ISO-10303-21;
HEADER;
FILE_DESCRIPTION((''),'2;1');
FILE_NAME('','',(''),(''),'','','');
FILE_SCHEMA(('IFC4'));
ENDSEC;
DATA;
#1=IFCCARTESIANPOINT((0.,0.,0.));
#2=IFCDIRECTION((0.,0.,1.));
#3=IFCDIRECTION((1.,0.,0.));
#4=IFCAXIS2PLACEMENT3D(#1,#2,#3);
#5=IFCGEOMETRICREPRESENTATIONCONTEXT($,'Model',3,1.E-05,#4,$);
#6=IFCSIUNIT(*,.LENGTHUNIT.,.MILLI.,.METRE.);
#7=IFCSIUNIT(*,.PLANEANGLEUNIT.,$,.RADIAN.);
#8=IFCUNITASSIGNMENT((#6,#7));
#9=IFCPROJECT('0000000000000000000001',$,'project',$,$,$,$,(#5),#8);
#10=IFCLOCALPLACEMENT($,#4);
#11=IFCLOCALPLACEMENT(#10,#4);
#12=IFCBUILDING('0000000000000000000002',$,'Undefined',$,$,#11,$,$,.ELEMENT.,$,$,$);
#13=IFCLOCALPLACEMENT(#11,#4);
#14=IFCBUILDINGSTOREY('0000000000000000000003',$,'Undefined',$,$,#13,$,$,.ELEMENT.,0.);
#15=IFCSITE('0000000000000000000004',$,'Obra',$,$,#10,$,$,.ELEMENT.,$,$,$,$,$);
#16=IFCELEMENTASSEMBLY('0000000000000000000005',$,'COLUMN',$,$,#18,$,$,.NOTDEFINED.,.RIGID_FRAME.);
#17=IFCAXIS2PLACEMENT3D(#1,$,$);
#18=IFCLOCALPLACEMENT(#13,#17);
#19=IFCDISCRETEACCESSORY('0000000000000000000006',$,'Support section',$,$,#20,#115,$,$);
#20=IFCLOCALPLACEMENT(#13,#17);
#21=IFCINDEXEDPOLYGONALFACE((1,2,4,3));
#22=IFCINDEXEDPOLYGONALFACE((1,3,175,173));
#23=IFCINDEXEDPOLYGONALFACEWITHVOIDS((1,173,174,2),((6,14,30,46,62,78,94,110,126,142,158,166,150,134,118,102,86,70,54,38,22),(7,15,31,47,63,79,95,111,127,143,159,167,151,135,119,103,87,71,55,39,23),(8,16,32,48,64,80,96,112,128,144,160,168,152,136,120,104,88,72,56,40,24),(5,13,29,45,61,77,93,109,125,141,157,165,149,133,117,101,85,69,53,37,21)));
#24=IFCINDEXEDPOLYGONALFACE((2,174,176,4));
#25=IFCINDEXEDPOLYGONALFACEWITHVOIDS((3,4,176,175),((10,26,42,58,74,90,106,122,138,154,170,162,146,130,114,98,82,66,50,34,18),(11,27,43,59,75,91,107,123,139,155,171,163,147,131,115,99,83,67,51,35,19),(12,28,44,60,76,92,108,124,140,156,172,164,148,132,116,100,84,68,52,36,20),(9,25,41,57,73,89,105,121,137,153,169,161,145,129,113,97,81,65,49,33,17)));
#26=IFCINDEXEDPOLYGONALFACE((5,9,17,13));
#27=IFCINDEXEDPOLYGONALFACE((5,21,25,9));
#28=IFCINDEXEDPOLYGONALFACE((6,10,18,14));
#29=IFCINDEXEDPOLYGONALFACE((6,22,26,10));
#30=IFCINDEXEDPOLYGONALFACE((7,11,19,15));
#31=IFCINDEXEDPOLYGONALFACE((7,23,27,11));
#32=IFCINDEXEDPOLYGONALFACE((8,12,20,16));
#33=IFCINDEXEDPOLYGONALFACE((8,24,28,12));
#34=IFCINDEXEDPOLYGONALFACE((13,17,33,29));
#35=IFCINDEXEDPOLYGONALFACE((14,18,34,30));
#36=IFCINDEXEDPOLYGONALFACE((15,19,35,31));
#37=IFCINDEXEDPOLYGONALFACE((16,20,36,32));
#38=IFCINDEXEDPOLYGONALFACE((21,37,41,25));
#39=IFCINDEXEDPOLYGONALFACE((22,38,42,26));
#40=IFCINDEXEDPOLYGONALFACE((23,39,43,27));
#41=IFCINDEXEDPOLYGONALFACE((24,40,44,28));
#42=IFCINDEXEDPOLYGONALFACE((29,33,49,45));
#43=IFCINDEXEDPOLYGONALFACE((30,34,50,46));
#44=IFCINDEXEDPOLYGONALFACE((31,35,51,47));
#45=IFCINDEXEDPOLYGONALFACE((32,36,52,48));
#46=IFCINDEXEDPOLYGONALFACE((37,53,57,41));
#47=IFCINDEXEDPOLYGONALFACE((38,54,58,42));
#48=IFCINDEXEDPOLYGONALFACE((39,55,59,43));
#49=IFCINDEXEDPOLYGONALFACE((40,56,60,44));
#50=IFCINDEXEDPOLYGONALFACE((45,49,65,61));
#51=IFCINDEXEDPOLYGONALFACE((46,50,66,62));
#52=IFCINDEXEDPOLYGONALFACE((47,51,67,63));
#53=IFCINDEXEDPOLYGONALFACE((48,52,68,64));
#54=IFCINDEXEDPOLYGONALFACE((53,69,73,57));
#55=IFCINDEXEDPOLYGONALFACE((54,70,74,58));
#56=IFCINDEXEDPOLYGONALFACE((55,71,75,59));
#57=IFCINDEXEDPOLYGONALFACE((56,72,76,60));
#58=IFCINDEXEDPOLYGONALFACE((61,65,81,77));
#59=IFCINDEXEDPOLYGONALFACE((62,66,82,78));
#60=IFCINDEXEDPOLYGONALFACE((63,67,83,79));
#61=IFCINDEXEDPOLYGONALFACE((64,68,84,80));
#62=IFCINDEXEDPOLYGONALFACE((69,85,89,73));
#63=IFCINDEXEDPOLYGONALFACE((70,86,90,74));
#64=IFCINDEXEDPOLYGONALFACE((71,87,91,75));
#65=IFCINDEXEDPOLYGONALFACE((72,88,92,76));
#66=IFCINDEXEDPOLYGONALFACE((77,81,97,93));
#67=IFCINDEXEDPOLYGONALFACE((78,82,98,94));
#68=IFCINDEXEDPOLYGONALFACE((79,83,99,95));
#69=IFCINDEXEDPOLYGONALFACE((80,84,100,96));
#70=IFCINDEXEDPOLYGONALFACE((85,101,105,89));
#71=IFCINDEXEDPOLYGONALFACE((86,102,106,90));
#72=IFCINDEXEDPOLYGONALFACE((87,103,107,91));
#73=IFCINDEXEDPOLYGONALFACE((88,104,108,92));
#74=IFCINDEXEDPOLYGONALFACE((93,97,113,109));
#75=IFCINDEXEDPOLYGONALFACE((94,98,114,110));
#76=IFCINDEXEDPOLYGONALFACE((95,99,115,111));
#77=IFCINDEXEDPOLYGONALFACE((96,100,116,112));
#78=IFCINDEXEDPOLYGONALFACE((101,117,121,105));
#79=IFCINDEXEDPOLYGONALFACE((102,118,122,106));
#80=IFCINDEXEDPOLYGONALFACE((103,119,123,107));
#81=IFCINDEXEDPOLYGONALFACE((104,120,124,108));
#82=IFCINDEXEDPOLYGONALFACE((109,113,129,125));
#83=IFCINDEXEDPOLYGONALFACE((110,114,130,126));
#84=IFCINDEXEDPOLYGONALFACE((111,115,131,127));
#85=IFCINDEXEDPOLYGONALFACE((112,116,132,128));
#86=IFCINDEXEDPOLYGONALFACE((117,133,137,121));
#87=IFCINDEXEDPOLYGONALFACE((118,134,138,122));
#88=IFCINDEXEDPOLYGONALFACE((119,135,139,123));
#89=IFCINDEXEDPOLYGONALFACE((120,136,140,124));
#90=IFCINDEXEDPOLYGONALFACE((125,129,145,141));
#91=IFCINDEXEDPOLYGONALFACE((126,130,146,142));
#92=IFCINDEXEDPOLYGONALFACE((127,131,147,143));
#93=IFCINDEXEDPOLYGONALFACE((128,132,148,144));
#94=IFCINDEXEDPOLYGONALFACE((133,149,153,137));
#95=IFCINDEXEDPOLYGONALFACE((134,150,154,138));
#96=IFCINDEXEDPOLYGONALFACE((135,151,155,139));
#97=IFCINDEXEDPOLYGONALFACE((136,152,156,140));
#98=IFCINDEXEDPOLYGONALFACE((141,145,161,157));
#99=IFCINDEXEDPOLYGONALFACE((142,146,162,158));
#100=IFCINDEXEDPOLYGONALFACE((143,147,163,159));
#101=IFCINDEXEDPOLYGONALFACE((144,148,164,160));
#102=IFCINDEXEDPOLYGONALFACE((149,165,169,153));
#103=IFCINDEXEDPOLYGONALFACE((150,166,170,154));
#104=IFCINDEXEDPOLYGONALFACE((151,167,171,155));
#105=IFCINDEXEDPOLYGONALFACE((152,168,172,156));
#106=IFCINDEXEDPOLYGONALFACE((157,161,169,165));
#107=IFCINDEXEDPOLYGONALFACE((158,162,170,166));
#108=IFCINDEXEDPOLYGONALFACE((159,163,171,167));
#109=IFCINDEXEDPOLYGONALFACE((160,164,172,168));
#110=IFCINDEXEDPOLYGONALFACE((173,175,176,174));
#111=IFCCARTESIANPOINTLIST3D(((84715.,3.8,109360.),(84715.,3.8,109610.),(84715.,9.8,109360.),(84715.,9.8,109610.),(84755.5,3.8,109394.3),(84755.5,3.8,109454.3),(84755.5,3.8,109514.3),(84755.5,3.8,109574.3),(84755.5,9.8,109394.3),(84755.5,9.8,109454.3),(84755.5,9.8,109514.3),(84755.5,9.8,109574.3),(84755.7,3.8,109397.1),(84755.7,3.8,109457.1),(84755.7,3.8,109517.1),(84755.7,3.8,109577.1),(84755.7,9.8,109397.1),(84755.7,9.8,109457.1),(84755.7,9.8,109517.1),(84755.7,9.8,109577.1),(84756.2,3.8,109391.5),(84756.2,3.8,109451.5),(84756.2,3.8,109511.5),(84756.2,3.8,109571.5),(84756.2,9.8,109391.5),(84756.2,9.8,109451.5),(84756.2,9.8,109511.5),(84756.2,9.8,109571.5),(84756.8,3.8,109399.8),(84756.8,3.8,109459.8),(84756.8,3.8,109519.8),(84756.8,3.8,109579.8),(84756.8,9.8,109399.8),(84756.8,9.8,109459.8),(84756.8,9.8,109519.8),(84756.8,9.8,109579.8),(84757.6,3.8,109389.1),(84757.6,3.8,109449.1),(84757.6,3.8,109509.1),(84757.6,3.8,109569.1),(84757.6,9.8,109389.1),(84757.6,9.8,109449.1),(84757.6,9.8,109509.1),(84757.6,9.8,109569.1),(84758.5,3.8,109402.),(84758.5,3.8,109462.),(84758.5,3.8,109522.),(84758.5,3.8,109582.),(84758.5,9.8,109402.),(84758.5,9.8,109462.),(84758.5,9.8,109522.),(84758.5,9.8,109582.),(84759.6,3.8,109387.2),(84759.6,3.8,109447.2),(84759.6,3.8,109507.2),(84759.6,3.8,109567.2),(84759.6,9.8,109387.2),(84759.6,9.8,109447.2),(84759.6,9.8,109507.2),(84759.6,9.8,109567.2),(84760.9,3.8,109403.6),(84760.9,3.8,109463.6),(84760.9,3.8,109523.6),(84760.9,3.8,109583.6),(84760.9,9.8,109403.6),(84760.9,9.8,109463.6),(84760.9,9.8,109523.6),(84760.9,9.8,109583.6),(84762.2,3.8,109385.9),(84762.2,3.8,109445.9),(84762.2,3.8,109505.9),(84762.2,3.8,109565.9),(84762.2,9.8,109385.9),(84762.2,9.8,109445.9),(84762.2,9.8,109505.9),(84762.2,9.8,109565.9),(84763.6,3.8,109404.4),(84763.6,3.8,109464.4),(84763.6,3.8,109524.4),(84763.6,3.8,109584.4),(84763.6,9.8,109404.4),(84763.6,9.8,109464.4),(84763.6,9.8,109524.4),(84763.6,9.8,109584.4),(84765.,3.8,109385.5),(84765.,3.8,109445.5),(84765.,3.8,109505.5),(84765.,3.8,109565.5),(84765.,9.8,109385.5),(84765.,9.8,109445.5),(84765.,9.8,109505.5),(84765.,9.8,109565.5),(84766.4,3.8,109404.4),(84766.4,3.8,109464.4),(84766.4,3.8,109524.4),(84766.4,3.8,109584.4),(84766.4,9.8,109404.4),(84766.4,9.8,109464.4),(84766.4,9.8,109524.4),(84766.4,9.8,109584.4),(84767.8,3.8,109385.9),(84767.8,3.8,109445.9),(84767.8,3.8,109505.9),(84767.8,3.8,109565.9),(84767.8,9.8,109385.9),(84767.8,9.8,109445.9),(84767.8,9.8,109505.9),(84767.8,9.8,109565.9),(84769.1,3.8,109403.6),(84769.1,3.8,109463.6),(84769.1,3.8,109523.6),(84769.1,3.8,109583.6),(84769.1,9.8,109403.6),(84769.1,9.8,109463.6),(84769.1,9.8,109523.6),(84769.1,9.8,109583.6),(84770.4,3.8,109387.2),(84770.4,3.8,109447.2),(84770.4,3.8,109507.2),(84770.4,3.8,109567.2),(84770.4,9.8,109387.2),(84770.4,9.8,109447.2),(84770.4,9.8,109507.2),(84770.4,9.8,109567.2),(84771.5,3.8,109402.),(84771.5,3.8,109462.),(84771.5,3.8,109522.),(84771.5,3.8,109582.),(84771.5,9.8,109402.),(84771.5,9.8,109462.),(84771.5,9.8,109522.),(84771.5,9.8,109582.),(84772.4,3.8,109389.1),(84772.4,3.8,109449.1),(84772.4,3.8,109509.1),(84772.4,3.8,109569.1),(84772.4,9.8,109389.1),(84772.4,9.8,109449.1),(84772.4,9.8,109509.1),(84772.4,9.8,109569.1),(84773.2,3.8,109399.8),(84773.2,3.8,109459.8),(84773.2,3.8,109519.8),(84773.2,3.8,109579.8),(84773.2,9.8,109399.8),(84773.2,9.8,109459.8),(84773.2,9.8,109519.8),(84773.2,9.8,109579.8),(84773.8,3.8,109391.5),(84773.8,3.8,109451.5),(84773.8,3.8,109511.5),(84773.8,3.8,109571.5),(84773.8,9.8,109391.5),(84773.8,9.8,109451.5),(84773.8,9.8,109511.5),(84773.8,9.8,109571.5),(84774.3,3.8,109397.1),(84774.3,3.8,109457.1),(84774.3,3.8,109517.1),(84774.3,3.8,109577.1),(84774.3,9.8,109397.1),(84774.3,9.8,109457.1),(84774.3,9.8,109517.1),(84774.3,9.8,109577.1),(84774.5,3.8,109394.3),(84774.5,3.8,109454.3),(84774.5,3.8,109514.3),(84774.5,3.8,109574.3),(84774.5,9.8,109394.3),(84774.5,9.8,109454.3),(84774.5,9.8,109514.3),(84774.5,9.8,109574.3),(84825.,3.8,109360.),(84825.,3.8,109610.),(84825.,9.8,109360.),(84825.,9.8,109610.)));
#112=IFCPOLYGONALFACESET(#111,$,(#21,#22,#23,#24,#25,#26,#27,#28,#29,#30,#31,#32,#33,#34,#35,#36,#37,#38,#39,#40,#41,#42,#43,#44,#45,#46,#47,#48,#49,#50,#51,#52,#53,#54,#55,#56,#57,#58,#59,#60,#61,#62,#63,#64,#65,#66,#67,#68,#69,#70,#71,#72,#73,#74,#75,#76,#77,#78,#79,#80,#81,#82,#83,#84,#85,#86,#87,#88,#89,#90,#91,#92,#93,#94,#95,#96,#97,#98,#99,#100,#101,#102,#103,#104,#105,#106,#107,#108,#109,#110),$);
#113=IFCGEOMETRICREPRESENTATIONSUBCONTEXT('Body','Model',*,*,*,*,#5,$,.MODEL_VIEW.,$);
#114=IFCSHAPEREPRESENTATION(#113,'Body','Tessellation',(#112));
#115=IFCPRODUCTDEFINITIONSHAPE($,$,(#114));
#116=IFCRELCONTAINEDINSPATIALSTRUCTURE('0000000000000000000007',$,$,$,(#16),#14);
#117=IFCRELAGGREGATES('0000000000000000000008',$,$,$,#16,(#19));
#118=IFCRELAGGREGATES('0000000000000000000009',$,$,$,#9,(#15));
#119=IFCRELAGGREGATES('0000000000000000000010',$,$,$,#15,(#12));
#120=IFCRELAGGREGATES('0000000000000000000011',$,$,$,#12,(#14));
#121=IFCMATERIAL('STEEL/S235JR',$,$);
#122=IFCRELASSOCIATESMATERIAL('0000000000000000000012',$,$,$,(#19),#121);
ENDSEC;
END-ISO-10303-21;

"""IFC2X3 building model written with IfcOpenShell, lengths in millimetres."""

from ifc_helpers import new_model, si_unit, frame, origin_with_axes, origin_2d_with_axis, place, context, subcontext, project, spatial, rectangle, circle, extrude, source, transform, mapped, material, element, aggregate, save


model = new_model("IFC2X3")

# Units and contexts
model_context = context("Model", 3, precision=1e-05, world=origin_with_axes())
body_context = subcontext(model_context, "Body", "Model", "MODEL_VIEW")
ifc_project = project(units=[si_unit("LENGTHUNIT", "METRE", prefix="MILLI"), si_unit("PLANEANGLEUNIT", "RADIAN")], contexts=[model_context])

# Site, building, storey
site_placement = place(None, origin_with_axes())
site = spatial("IfcSite", under=ifc_project, at=site_placement, Name="Obra", CompositionType="ELEMENT")
building_placement = place(site_placement, origin_with_axes())
building = spatial("IfcBuilding", under=site, at=building_placement, Name="Undefined", CompositionType="ELEMENT")
storey_placement = place(building_placement, origin_with_axes())
storey = spatial("IfcBuildingStorey", under=building, at=storey_placement, Name="Undefined", CompositionType="ELEMENT", Elevation=0.0)

# Element assembly, discrete accessory, opening
assembly_1_placement = place(storey_placement, origin_with_axes())
assembly_1 = element("IfcElementAssembly", 1, at=assembly_1_placement, inside=storey, Name="COLUMN", AssemblyPlace="NOTDEFINED", PredefinedType="RIGID_FRAME")
ifc_material_1 = material(Name="STEEL/S235JR")
shared_shape_1 = source(origin_with_axes(), body_context, "Body", "SweptSolid", [
    extrude(circle(Radius=9.5, at=origin_2d_with_axis()), frame((0.0, -9.8, 0.0), z_axis=(0.0, 1.0, 0.0), x_axis=(1.0, 0.0, 0.0)), (0.0, 0.0, 1.0), 6.2),
])
discrete_accessory_1_placement = place(assembly_1_placement, frame((84770.0, 6.8, 109360.0), z_axis=(0.0, 0.0, 1.0), x_axis=(1.0, 0.0, 0.0)))
discrete_accessory_1 = element("IfcDiscreteAccessory", 2, at=discrete_accessory_1_placement, material=ifc_material_1, Name="Support section", context=body_context, shape_type="SweptSolid", body=[
    extrude(rectangle(XDim=6.0, YDim=110.0, at=origin_2d_with_axis()), frame((0.0, 0.0, 250.0), z_axis=(0.0, 0.0, -1.0), x_axis=(0.0, 1.0, 0.0)), (0.0, 0.0, 1.0), 250.0),
])
opening_1_placement = place(assembly_1_placement, frame((84815.0, 0.0, 109650.0), z_axis=(-1.0, 0.0, 0.0), x_axis=(0.0, 0.0, -1.0)))
element("IfcOpeningElement", 3, at=opening_1_placement, cuts=discrete_accessory_1, ObjectType="Opening", context=body_context, shape_type="MappedRepresentation", body=[
    mapped(shared_shape_1, transform((75.0, 0.0, 50.0))),
    mapped(shared_shape_1, transform((135.0, 0.0, 50.0))),
    mapped(shared_shape_1, transform((195.0, 0.0, 50.0))),
    mapped(shared_shape_1, transform((255.0, 0.0, 50.0))),
])
aggregate(assembly_1, [discrete_accessory_1])

save(model, "model.ifc")
